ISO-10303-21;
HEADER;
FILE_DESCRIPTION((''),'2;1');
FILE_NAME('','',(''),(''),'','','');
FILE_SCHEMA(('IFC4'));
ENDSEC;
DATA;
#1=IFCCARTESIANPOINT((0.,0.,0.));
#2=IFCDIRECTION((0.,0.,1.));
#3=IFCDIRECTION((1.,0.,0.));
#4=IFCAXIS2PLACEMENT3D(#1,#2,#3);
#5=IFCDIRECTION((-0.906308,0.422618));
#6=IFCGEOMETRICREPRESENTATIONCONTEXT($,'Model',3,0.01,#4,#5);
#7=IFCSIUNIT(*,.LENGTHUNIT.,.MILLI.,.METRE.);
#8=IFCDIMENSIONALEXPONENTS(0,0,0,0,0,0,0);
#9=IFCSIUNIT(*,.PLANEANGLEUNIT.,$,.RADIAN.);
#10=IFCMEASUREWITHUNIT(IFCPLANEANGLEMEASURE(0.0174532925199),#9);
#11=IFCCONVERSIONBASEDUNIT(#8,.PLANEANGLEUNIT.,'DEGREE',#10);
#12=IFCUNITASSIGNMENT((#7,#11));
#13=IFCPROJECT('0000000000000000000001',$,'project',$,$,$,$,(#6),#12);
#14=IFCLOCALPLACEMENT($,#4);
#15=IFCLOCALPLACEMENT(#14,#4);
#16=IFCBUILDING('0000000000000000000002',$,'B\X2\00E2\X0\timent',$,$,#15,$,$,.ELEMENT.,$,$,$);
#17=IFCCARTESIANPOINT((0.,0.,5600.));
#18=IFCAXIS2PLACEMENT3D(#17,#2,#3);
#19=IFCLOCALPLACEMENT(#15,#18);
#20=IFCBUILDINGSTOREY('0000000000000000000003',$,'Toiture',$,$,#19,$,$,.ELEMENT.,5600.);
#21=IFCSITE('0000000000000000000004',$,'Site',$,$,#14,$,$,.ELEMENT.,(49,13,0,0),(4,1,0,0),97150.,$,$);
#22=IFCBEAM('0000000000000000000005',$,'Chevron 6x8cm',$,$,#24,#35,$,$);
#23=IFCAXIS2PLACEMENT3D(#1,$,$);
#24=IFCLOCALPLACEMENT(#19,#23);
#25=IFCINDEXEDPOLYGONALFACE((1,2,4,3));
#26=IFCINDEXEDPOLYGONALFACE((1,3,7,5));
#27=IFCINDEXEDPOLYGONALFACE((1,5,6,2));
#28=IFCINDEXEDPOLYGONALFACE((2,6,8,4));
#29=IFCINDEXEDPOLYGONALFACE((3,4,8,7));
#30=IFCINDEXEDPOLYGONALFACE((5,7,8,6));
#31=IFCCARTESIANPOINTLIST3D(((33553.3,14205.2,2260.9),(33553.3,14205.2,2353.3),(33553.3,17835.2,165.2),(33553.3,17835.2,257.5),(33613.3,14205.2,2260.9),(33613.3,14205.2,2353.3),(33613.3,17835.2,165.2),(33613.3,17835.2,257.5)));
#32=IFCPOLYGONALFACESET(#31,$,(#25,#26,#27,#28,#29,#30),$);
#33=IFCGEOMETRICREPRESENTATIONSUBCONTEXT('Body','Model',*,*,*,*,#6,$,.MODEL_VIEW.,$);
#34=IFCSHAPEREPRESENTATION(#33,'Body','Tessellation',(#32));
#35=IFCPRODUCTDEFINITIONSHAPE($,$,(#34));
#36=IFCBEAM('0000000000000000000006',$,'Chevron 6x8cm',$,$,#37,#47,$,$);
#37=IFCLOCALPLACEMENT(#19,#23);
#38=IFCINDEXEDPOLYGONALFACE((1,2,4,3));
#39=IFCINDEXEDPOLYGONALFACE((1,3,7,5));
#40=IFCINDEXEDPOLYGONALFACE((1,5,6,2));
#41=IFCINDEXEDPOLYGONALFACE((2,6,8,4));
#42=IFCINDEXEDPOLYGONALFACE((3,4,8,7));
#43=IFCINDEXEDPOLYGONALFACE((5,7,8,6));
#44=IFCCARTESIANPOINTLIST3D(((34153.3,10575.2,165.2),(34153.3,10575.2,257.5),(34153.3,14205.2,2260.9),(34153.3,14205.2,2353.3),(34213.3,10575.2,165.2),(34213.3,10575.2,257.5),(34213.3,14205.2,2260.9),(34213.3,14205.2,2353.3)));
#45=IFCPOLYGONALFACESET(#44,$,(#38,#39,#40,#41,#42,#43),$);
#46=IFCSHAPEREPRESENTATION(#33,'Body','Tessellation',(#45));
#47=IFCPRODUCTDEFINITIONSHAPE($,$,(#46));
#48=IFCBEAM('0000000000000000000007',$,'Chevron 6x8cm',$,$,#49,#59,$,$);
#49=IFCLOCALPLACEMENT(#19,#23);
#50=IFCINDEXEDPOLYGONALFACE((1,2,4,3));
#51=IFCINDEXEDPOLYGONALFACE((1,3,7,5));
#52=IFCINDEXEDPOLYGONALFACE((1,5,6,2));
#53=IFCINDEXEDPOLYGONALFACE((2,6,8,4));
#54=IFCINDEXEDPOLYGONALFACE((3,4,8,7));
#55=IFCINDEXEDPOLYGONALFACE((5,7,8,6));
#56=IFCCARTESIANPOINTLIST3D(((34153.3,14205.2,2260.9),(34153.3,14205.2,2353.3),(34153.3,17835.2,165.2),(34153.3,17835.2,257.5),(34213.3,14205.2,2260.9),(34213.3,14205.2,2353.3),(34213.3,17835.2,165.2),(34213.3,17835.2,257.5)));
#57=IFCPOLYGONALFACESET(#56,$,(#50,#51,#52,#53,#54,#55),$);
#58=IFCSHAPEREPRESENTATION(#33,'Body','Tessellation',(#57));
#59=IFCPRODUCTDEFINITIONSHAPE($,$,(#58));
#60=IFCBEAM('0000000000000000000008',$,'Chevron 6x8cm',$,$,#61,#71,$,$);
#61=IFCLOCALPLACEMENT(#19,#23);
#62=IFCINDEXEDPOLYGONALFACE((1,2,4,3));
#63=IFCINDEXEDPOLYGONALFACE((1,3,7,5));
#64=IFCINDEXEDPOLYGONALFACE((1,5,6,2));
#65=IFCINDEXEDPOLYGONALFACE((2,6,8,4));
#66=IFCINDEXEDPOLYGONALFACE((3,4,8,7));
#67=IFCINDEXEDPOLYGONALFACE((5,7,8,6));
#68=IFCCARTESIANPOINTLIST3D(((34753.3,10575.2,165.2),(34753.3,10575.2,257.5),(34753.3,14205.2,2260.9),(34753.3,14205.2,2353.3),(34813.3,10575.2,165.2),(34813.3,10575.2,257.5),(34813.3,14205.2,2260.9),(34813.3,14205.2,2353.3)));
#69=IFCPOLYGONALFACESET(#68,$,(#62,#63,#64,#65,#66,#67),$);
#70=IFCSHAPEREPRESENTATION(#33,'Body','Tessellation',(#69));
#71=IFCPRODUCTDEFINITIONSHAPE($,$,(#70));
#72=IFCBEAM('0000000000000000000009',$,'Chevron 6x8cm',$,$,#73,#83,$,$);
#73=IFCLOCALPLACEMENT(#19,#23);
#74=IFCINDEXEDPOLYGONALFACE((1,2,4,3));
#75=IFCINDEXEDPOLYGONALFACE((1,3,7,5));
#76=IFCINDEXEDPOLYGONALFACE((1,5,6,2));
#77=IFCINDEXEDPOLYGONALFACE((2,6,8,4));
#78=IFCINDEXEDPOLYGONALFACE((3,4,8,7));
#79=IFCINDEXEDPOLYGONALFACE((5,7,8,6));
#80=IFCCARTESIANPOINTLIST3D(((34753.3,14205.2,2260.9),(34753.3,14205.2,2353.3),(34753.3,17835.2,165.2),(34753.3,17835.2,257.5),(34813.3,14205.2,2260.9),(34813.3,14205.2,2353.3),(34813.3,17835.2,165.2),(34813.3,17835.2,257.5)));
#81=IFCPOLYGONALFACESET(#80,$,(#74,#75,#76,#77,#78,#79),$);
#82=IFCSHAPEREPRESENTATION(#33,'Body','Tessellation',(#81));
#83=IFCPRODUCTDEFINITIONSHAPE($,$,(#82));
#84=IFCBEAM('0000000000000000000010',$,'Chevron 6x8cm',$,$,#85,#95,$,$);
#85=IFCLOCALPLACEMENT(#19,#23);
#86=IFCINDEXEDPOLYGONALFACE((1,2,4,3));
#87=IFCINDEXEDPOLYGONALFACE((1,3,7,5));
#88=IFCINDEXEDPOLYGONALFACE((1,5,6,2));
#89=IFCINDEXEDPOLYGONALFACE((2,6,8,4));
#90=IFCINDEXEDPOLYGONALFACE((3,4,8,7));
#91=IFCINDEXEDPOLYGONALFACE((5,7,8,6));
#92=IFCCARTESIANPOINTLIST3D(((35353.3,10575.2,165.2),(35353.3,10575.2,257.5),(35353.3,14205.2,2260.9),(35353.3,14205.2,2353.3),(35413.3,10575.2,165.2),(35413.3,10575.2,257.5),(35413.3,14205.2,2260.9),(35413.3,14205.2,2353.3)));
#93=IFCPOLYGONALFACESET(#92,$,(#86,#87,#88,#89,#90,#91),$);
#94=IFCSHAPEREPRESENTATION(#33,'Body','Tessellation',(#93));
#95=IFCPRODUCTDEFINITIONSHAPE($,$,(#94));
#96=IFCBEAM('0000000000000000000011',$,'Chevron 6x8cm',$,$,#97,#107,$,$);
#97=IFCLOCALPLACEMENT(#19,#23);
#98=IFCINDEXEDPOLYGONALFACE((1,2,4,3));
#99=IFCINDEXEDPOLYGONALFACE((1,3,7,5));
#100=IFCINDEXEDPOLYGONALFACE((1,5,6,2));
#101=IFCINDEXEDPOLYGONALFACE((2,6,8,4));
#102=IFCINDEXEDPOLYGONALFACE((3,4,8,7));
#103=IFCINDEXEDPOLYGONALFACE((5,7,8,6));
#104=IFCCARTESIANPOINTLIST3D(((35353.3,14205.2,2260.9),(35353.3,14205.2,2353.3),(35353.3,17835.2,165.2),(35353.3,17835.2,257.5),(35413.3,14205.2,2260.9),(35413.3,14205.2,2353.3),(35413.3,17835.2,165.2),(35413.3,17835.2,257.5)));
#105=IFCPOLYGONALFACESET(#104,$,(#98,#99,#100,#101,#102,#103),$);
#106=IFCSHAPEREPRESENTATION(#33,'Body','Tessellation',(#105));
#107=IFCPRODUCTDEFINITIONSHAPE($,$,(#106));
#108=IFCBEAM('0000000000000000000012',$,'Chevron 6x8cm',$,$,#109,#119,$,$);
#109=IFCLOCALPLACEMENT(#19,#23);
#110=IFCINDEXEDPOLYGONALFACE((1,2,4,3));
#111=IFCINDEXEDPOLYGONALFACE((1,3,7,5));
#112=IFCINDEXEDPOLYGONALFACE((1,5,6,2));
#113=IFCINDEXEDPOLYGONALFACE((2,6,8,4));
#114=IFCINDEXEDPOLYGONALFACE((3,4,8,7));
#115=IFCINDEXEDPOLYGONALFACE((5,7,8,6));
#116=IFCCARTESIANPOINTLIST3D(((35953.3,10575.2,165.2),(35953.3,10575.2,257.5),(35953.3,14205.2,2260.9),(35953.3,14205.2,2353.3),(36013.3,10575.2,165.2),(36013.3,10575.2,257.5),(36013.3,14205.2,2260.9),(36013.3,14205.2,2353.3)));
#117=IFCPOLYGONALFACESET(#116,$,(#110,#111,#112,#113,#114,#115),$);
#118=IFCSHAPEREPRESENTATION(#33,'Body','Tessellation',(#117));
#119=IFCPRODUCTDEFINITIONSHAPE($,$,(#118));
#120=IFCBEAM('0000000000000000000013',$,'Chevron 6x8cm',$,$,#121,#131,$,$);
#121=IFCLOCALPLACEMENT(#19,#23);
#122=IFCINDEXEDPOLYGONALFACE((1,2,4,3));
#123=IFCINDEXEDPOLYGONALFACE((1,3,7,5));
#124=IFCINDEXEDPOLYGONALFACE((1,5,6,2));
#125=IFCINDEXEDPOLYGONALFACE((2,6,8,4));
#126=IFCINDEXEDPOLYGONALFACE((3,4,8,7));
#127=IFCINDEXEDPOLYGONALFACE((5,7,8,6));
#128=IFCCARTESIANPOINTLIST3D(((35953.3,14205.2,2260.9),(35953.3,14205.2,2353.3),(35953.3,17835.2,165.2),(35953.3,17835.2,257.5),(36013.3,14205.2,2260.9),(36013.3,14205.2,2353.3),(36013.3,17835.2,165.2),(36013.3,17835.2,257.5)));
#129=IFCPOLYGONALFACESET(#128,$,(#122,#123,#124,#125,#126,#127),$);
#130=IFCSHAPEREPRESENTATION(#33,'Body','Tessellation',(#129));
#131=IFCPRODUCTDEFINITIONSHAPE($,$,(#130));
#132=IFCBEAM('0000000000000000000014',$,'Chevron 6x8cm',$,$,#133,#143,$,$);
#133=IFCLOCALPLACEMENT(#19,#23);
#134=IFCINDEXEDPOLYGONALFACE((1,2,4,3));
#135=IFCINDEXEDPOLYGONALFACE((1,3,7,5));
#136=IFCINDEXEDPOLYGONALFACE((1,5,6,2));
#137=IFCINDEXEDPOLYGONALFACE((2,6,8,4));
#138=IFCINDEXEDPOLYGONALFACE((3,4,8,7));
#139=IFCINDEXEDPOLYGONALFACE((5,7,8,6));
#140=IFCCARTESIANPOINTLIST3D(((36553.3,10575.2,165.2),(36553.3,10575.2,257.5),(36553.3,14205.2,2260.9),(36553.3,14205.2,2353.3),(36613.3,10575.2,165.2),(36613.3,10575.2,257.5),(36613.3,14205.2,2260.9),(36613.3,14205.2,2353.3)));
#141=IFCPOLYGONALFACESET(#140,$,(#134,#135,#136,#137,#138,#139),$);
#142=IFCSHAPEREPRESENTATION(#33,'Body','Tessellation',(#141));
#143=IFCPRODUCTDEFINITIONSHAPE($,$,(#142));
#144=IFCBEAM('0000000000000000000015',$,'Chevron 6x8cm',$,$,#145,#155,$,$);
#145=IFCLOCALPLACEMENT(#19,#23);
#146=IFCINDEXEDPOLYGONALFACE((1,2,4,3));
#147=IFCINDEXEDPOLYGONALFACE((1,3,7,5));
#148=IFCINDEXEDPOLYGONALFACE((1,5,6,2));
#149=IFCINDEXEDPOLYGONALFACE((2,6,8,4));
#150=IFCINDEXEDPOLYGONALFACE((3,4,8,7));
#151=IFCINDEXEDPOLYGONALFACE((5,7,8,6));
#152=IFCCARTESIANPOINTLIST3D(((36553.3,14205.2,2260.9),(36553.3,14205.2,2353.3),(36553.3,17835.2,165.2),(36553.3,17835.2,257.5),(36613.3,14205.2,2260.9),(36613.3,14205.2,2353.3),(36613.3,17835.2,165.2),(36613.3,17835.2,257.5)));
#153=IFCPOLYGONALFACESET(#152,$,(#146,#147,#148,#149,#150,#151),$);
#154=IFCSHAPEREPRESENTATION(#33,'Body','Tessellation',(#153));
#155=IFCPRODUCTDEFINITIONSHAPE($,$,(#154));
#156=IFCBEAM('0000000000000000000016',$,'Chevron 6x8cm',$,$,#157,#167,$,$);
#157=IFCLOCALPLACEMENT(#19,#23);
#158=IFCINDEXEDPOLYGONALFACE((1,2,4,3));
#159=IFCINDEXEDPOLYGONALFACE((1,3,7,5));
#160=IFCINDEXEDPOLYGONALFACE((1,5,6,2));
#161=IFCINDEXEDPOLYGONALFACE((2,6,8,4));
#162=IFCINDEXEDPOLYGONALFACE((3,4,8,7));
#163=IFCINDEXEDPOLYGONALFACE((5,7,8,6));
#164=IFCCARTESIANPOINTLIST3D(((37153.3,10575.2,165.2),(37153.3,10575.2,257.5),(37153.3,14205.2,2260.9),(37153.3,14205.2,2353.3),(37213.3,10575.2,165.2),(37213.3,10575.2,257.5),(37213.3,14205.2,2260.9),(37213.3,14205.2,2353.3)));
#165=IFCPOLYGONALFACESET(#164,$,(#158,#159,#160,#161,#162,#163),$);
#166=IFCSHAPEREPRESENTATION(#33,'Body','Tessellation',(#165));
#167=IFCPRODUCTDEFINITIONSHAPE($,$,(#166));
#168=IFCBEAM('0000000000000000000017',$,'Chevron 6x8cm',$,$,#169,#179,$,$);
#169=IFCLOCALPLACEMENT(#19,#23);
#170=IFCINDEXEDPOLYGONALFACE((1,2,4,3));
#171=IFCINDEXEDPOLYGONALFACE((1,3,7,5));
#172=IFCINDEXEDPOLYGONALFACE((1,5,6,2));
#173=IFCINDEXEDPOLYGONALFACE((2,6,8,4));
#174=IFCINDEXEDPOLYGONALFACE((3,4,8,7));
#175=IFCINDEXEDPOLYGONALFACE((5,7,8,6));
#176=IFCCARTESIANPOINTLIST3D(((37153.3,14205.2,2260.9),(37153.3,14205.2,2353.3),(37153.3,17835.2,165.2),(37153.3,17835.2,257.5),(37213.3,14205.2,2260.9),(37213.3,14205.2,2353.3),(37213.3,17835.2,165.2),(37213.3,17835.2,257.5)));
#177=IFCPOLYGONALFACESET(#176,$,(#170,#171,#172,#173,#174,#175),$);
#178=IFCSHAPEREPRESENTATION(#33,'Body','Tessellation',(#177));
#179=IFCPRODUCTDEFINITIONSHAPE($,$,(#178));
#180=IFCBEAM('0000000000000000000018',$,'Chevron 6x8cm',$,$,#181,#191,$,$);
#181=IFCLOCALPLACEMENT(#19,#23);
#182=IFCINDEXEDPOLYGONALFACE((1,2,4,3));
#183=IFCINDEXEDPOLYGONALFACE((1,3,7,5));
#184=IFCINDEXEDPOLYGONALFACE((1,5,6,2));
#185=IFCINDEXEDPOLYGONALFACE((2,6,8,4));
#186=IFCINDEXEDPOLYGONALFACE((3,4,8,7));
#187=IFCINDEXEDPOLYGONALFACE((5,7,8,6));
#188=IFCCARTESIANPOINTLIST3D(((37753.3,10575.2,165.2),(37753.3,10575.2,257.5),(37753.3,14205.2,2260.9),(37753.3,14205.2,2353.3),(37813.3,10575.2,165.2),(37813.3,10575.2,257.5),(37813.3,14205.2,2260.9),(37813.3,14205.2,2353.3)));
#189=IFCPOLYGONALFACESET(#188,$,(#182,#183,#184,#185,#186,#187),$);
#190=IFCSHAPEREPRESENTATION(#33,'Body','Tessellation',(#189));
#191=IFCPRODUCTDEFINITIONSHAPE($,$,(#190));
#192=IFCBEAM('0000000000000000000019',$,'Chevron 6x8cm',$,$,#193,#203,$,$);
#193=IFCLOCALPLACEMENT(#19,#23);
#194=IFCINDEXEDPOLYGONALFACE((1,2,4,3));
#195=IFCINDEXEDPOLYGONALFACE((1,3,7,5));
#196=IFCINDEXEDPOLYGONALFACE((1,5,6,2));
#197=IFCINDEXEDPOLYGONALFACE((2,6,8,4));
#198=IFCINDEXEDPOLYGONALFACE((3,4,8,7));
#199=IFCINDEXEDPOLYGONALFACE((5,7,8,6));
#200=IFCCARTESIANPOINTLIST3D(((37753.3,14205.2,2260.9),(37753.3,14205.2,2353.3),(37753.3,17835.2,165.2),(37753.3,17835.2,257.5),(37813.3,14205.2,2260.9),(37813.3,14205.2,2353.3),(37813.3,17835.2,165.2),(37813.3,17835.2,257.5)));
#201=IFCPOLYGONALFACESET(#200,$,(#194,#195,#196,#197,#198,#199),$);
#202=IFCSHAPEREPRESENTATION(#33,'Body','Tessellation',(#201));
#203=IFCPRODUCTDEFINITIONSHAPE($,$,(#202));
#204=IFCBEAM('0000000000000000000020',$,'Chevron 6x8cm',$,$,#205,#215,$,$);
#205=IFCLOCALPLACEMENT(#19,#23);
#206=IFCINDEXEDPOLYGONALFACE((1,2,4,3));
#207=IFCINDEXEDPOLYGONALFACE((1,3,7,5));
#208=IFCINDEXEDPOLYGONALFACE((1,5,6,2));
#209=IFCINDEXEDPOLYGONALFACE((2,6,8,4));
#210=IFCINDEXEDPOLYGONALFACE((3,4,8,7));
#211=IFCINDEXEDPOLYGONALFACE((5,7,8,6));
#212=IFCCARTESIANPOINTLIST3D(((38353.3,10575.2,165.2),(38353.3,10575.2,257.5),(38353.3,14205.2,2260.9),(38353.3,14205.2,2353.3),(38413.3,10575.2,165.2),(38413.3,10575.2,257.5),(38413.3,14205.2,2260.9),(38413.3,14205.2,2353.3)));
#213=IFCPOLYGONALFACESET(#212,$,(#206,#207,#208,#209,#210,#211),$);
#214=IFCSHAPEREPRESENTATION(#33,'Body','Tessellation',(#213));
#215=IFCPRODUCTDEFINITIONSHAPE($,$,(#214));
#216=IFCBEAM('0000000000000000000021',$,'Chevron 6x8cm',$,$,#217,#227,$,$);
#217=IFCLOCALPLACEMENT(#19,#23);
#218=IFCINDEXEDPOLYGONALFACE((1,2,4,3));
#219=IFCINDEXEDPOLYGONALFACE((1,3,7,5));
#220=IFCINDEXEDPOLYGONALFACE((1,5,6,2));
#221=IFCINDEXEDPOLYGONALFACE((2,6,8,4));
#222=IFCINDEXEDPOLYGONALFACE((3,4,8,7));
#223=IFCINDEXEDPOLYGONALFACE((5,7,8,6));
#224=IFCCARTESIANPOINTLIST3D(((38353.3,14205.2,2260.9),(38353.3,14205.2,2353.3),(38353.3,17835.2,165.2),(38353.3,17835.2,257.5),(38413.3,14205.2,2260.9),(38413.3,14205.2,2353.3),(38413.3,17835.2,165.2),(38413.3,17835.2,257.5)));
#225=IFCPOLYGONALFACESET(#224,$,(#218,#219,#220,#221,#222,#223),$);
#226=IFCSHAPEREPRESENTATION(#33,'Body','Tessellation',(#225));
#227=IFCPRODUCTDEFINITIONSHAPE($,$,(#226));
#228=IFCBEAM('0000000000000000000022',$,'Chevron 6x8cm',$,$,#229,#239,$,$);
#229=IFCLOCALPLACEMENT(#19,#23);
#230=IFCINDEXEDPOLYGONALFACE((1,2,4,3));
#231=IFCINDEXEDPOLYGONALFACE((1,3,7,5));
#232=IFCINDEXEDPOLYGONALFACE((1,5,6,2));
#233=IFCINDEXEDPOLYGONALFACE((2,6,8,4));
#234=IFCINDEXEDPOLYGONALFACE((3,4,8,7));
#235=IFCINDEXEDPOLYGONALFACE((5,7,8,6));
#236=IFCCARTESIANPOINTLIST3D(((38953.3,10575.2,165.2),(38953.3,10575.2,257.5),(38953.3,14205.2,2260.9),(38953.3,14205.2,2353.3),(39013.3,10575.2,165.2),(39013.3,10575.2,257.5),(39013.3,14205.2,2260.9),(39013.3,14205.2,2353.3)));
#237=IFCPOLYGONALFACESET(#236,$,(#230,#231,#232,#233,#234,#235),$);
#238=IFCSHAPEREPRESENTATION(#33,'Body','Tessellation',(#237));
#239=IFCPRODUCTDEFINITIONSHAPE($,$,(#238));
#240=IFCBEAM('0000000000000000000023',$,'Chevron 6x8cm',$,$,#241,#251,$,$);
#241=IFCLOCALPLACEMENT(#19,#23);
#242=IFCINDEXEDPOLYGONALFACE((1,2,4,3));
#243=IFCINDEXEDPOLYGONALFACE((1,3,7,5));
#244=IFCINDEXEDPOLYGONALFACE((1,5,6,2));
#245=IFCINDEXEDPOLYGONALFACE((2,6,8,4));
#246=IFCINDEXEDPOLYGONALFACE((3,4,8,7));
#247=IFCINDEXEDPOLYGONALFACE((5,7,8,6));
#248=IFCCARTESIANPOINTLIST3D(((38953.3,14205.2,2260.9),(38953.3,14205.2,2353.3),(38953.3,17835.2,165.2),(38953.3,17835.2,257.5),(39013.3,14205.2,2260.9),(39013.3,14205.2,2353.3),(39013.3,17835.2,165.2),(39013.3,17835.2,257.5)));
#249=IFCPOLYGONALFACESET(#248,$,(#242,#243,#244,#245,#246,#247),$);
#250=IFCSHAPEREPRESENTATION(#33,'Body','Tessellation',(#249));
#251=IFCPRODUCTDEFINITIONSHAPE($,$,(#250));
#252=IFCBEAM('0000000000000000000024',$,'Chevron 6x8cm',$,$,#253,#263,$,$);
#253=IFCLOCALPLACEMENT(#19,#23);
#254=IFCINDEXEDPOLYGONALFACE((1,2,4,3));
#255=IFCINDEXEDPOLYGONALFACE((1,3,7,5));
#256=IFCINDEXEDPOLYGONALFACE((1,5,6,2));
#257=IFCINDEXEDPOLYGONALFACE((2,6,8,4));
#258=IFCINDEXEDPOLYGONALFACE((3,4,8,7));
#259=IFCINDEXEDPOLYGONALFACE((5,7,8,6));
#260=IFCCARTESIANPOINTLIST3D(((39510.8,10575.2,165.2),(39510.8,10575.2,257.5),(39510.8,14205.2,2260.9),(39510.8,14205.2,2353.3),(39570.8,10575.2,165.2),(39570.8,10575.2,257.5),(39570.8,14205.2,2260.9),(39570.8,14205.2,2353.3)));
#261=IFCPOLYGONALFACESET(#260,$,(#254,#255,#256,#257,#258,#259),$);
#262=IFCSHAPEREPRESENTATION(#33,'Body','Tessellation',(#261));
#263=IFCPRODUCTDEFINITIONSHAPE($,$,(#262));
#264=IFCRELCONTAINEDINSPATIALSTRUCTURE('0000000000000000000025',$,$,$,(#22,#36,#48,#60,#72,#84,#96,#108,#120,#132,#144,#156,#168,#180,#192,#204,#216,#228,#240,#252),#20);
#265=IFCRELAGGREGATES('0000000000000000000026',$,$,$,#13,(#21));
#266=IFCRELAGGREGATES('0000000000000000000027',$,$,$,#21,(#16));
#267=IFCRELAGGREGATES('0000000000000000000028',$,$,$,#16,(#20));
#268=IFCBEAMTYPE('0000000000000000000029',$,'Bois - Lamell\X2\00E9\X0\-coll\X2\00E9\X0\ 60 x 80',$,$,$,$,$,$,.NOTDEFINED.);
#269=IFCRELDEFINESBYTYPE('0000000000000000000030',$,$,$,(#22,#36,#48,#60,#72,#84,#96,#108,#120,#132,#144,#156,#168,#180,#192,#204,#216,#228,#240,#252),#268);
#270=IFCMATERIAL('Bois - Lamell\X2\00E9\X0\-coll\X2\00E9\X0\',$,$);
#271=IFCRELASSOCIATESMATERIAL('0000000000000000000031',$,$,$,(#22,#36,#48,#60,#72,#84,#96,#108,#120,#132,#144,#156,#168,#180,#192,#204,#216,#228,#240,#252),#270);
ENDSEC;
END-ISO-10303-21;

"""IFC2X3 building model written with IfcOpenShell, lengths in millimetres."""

from ifc_helpers import new_model, entity, si_unit, converted_unit, direction, frame, frame_2d, origin_with_axes, place, context, subcontext, project, spatial, rectangle, extrude, clip, halfspace, material, type_object, element, save


model = new_model("IFC2X3")

# Units and contexts
model_context = context("Model", 3, precision=0.01, world=origin_with_axes(), true_north=direction((-0.906308, 0.422618)))
body_context = subcontext(model_context, "Body", "Model", "MODEL_VIEW")
ifc_project = project(units=[si_unit("LENGTHUNIT", "METRE", prefix="MILLI"), converted_unit("PLANEANGLEUNIT", "DEGREE", entity("IfcPlaneAngleMeasure", 0.0174532925199), si_unit("PLANEANGLEUNIT", "RADIAN"), dimensions=[0, 0, 0, 0, 0, 0, 0])], contexts=[model_context])

# Site, building, storey
site_placement = place(None, origin_with_axes())
site = spatial("IfcSite", under=ifc_project, at=site_placement, Name="Site", CompositionType="ELEMENT", RefLatitude=(49, 13, 0, 0), RefLongitude=(4, 1, 0, 0), RefElevation=97150.0)
building_placement = place(site_placement, origin_with_axes())
building = spatial("IfcBuilding", under=site, at=building_placement, Name="Bâtiment", CompositionType="ELEMENT")
storey_placement = place(building_placement, frame((0.0, 0.0, 5600.0), z_axis=(0.0, 0.0, 1.0), x_axis=(1.0, 0.0, 0.0)))
storey = spatial("IfcBuildingStorey", under=building, at=storey_placement, Name="Toiture", CompositionType="ELEMENT", Elevation=5600.0)

# Beams
ifc_material = material(Name="Bois - Lamellé-collé")
beam_type = type_object("IfcBeamType", Name="Bois - Lamellé-collé 60 x 80", PredefinedType="NOTDEFINED")
for number, where, z_axis, x_axis, name in (
    (1, (33583.3, 17835.2, 257.5), (0.0, 0.0, 1.0), (-1.0, 0.0, 0.0), "Chevron 6x8cm"),
    (2, (34183.3, 10575.2, 257.5), (0.0, 0.0, 1.0), (1.0, 0.0, 0.0), "Chevron 6x8cm"),
    (3, (34183.3, 17835.2, 257.5), (0.0, 0.0, 1.0), (-1.0, 0.0, 0.0), "Chevron 6x8cm"),
    (4, (34783.3, 10575.2, 257.5), (0.0, 0.0, 1.0), (1.0, 0.0, 0.0), "Chevron 6x8cm"),
    (5, (34783.3, 17835.2, 257.5), (0.0, 0.0, 1.0), (-1.0, 0.0, 0.0), "Chevron 6x8cm"),
    (6, (35383.3, 10575.2, 257.5), (0.0, 0.0, 1.0), (1.0, 0.0, 0.0), "Chevron 6x8cm"),
    (7, (35383.3, 17835.2, 257.5), (0.0, 0.0, 1.0), (-1.0, 0.0, 0.0), "Chevron 6x8cm"),
    (8, (35983.3, 10575.2, 257.5), (0.0, 0.0, 1.0), (1.0, 0.0, 0.0), "Chevron 6x8cm"),
    (9, (35983.3, 17835.2, 257.5), (0.0, 0.0, 1.0), (-1.0, 0.0, 0.0), "Chevron 6x8cm"),
    (10, (36583.3, 10575.2, 257.5), (0.0, 0.0, 1.0), (1.0, 0.0, 0.0), "Chevron 6x8cm"),
    (11, (36583.3, 17835.2, 257.5), (0.0, 0.0, 1.0), (-1.0, 0.0, 0.0), "Chevron 6x8cm"),
    (12, (37183.3, 10575.2, 257.5), (0.0, 0.0, 1.0), (1.0, 0.0, 0.0), "Chevron 6x8cm"),
    (13, (37183.3, 17835.2, 257.5), (0.0, 0.0, 1.0), (-1.0, 0.0, 0.0), "Chevron 6x8cm"),
    (14, (37783.3, 10575.2, 257.5), (0.0, 0.0, 1.0), (1.0, 0.0, 0.0), "Chevron 6x8cm"),
    (15, (37783.3, 17835.2, 257.5), (0.0, 0.0, 1.0), (-1.0, 0.0, 0.0), "Chevron 6x8cm"),
    (16, (38383.3, 10575.2, 257.5), (0.0, 0.0, 1.0), (1.0, 0.0, 0.0), "Chevron 6x8cm"),
    (17, (38383.3, 17835.2, 257.5), (0.0, 0.0, 1.0), (-1.0, 0.0, 0.0), "Chevron 6x8cm"),
    (18, (38983.3, 10575.2, 257.5), (0.0, 0.0, 1.0), (1.0, 0.0, 0.0), "Chevron 6x8cm"),
    (19, (38983.3, 17835.2, 257.5), (0.0, 0.0, 1.0), (-1.0, 0.0, 0.0), "Chevron 6x8cm"),
    (20, (39540.8, 10575.2, 257.5), (0.0, 0.0, 1.0), (1.0, 0.0, 0.0), "Chevron 6x8cm"),
):
    element("IfcBeam", number, at=place(storey_placement, frame(where, z_axis=z_axis, x_axis=x_axis)), inside=storey, type_object=beam_type, material=ifc_material, Name=name, context=body_context, shape_type="Clipping", body=[
        clip(clip(extrude(rectangle(XDim=80.0, YDim=60.0, at=frame_2d((-40.0, 0.0), x_axis=(1.0, 0.0))), frame((0.0, -56.6, -32.7), z_axis=(0.0, 0.866025, 0.5), x_axis=(0.0, -0.5, 0.866025)), (0.0, 0.0, 1.0), 4322.2), halfspace(frame((0.0, 0.0, 0.0), z_axis=(0.0, 1.0, 0.0), x_axis=(0.0, 0.0, 1.0)), True)), halfspace(frame((0.0, 3630.0, 0.0), z_axis=(0.0, -1.0, 0.0), x_axis=(0.0, 0.0, -1.0)), True)),
    ])

save(model, "model.ifc")
